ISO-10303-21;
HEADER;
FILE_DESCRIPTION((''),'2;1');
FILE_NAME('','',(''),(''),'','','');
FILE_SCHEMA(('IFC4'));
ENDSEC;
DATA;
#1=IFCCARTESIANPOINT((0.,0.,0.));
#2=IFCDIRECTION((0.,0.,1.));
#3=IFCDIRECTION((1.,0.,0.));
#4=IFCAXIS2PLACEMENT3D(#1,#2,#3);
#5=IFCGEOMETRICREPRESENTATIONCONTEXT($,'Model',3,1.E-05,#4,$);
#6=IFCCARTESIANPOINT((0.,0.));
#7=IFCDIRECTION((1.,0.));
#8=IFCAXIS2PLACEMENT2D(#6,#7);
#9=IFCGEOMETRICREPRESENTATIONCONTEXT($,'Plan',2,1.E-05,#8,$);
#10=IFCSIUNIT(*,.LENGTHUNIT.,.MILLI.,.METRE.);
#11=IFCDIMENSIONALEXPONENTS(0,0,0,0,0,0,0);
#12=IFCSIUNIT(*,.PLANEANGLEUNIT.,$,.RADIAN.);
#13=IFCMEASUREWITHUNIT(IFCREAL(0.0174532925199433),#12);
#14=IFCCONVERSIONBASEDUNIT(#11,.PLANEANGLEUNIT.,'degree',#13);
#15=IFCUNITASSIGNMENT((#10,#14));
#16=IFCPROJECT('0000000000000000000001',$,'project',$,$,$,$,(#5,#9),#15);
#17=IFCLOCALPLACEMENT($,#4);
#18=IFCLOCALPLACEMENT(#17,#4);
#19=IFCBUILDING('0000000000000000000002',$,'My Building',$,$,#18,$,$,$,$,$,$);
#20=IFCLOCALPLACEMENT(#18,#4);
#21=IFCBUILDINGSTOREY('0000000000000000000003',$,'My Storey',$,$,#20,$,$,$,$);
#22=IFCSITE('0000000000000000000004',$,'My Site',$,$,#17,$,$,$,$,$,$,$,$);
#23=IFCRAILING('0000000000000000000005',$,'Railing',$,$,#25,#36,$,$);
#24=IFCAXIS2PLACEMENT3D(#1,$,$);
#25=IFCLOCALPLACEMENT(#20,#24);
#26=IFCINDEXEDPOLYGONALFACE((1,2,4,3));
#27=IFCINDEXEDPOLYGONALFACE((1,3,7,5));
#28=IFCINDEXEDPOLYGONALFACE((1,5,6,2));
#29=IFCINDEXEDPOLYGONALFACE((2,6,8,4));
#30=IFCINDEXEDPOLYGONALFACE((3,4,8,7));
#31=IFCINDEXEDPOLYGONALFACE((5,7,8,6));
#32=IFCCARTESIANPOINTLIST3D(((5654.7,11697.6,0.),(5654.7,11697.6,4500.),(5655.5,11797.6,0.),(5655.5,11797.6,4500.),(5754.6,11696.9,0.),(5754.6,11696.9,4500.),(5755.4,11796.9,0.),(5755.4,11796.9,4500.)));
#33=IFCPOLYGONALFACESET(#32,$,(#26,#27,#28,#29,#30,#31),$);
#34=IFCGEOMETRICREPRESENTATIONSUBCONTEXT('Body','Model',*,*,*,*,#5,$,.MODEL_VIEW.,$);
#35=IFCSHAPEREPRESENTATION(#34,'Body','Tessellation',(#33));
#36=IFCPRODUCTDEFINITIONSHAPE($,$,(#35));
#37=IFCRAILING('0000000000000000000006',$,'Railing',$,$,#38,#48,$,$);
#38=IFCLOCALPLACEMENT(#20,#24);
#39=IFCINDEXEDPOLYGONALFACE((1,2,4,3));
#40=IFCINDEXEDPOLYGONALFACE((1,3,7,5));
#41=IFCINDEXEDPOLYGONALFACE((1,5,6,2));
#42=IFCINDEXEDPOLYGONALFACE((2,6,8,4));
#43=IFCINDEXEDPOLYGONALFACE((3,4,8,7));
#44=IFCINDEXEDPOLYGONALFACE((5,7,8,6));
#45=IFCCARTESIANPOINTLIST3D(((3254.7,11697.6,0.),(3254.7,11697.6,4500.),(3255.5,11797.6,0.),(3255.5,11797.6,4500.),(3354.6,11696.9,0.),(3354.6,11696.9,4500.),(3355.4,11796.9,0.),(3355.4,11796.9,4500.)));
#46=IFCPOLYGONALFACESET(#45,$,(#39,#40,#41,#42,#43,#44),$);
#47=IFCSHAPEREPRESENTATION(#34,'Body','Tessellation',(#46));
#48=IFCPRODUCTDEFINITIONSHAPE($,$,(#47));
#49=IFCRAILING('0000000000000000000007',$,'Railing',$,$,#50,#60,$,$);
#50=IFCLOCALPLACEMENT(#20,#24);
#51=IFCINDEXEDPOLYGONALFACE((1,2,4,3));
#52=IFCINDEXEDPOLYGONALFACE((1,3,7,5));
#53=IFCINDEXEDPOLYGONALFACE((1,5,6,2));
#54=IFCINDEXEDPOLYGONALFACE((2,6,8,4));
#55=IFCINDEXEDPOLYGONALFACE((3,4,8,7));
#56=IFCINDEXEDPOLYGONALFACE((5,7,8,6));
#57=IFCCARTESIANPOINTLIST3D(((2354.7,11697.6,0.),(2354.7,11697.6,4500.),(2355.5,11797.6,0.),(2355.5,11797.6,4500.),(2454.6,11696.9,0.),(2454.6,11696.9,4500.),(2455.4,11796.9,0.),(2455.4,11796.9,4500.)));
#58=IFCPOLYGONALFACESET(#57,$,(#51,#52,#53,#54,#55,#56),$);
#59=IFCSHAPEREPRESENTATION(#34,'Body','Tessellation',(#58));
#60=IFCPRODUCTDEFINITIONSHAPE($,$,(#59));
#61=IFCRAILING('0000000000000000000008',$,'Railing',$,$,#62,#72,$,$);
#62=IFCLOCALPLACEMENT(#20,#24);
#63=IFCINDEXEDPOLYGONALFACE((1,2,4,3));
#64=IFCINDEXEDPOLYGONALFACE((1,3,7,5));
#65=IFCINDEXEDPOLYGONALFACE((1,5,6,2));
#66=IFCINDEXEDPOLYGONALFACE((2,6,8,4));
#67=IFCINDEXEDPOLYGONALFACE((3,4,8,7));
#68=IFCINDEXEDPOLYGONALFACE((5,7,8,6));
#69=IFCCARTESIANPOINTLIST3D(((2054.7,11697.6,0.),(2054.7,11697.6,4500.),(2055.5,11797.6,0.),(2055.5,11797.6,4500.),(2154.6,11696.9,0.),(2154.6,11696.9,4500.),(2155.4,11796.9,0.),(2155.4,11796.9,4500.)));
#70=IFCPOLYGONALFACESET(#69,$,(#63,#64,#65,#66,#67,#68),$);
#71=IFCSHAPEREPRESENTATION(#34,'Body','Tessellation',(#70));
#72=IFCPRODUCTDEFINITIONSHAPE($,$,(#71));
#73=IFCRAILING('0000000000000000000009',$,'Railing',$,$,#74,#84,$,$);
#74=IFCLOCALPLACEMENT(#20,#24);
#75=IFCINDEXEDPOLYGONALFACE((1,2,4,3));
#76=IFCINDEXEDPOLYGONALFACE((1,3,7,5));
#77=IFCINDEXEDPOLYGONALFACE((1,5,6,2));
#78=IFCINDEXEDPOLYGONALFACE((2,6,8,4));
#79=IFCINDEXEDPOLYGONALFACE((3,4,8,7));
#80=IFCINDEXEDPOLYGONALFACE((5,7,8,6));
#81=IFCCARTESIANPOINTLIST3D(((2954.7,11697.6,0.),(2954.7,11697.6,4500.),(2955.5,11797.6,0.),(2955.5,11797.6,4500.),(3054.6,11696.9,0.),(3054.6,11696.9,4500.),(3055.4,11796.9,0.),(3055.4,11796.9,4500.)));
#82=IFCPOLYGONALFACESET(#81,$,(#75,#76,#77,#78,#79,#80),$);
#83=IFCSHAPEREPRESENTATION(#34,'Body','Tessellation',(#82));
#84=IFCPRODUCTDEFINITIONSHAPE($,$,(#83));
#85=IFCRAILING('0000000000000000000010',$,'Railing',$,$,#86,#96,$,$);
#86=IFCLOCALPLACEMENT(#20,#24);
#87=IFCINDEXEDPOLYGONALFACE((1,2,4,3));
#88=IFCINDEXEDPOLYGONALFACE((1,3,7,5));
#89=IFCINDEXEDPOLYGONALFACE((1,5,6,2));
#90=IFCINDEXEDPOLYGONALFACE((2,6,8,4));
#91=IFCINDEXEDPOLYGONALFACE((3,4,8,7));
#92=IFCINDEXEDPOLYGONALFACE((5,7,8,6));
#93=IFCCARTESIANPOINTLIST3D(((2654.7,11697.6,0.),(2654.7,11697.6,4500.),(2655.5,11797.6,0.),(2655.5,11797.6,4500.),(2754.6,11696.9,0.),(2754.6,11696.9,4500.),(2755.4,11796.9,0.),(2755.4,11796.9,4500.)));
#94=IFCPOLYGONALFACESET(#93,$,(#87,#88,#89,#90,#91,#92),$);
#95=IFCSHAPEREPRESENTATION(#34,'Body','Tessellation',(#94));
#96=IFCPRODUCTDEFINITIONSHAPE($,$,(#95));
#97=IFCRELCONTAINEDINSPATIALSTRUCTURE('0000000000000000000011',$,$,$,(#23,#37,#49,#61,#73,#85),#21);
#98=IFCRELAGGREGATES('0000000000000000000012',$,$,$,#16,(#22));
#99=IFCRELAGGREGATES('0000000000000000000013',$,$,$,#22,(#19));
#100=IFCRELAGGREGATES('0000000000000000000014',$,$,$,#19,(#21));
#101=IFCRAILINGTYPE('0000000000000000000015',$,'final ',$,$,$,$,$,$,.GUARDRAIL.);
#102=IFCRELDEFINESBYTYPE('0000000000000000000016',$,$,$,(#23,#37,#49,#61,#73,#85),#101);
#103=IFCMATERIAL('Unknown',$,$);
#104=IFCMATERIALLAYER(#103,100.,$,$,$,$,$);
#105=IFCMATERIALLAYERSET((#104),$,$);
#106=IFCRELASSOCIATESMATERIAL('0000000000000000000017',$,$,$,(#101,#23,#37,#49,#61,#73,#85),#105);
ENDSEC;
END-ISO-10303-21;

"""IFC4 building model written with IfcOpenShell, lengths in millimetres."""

from ifc_helpers import new_model, entity, si_unit, converted_unit, frame, origin_with_axes, origin_2d_with_axis, place, context, subcontext, project, spatial, line, indexed_curve, outline, extrude, material, layer, layer_set, layer_usage, type_object, element, save


model = new_model("IFC4")

# Units and contexts
model_context = context("Model", 3, precision=1e-05, world=origin_with_axes())
plan_context = context("Plan", 2, precision=1e-05, world=origin_2d_with_axis())
body_context = subcontext(model_context, "Body", "Model", "MODEL_VIEW")
ifc_project = project(units=[si_unit("LENGTHUNIT", "METRE", prefix="MILLI"), converted_unit("PLANEANGLEUNIT", "degree", entity("IfcReal", 0.0174532925199433), si_unit("PLANEANGLEUNIT", "RADIAN"), dimensions=[0, 0, 0, 0, 0, 0, 0])], contexts=[model_context, plan_context])

# Site, building, storey
site_placement = place(None, origin_with_axes())
site = spatial("IfcSite", under=ifc_project, at=site_placement, Name="My Site")
building_placement = place(site_placement, origin_with_axes())
building = spatial("IfcBuilding", under=site, at=building_placement, Name="My Building")
storey_placement = place(building_placement, origin_with_axes())
storey = spatial("IfcBuildingStorey", under=building, at=storey_placement, Name="My Storey")

# Shared definitions
ifc_material = material(Name="Unknown")

# Railings
ifc_layer_1 = layer(ifc_material, 100.0)
ifc_layer_set_1 = layer_set([ifc_layer_1])
railing_type = type_object("IfcRailingType", Name="final ", PredefinedType="GUARDRAIL", material=ifc_layer_set_1)
ifc_layer_usage_1 = layer_usage(ifc_layer_set_1, "AXIS2", "POSITIVE", 0.0)
railing_1_placement = place(storey_placement, frame((5755.4, 11796.9, 0.0), z_axis=(0.0, 0.0, 1.0), x_axis=(-0.99997, 0.007689, 0.0)))
element("IfcRailing", 1, at=railing_1_placement, inside=storey, type_object=railing_type, material=ifc_layer_usage_1, Name="Railing", context=body_context, shape_type="SweptSolid", body=[
    extrude(outline(indexed_curve([(0.0, 0.0), (0.0, 100.0), (99.8, 100.0), (99.8, 0.0)], segments=[line(1, 2, 3, 4, 1)])), origin_with_axes(), (0.0, 0.0, 1.0), 4500.0),
])
ifc_layer_usage_2 = layer_usage(ifc_layer_set_1, "AXIS2", "POSITIVE", 0.0)
railing_2_placement = place(storey_placement, frame((3355.4, 11796.9, 0.0), z_axis=(0.0, 0.0, 1.0), x_axis=(-0.99997, 0.007689, 0.0)))
element("IfcRailing", 2, at=railing_2_placement, inside=storey, type_object=railing_type, material=ifc_layer_usage_2, Name="Railing", context=body_context, shape_type="SweptSolid", body=[
    extrude(outline(indexed_curve([(0.0, 0.0), (0.0, 100.0), (99.8, 100.0), (99.8, 0.0)], segments=[line(1, 2, 3, 4, 1)])), origin_with_axes(), (0.0, 0.0, 1.0), 4500.0),
])
ifc_layer_usage_3 = layer_usage(ifc_layer_set_1, "AXIS2", "POSITIVE", 0.0)
railing_3_placement = place(storey_placement, frame((2455.4, 11796.9, 0.0), z_axis=(0.0, 0.0, 1.0), x_axis=(-0.99997, 0.007689, 0.0)))
element("IfcRailing", 3, at=railing_3_placement, inside=storey, type_object=railing_type, material=ifc_layer_usage_3, Name="Railing", context=body_context, shape_type="SweptSolid", body=[
    extrude(outline(indexed_curve([(0.0, 0.0), (0.0, 100.0), (99.8, 100.0), (99.8, 0.0)], segments=[line(1, 2, 3, 4, 1)])), origin_with_axes(), (0.0, 0.0, 1.0), 4500.0),
])
ifc_layer_usage_4 = layer_usage(ifc_layer_set_1, "AXIS2", "POSITIVE", 0.0)
railing_4_placement = place(storey_placement, frame((2155.4, 11796.9, 0.0), z_axis=(0.0, 0.0, 1.0), x_axis=(-0.99997, 0.007689, 0.0)))
element("IfcRailing", 4, at=railing_4_placement, inside=storey, type_object=railing_type, material=ifc_layer_usage_4, Name="Railing", context=body_context, shape_type="SweptSolid", body=[
    extrude(outline(indexed_curve([(0.0, 0.0), (0.0, 100.0), (99.8, 100.0), (99.8, 0.0)], segments=[line(1, 2, 3, 4, 1)])), origin_with_axes(), (0.0, 0.0, 1.0), 4500.0),
])
ifc_layer_usage_5 = layer_usage(ifc_layer_set_1, "AXIS2", "POSITIVE", 0.0)
railing_5_placement = place(storey_placement, frame((3055.4, 11796.9, 0.0), z_axis=(0.0, 0.0, 1.0), x_axis=(-0.99997, 0.007689, 0.0)))
element("IfcRailing", 5, at=railing_5_placement, inside=storey, type_object=railing_type, material=ifc_layer_usage_5, Name="Railing", context=body_context, shape_type="SweptSolid", body=[
    extrude(outline(indexed_curve([(0.0, 0.0), (0.0, 100.0), (99.8, 100.0), (99.8, 0.0)], segments=[line(1, 2, 3, 4, 1)])), origin_with_axes(), (0.0, 0.0, 1.0), 4500.0),
])
ifc_layer_usage_6 = layer_usage(ifc_layer_set_1, "AXIS2", "POSITIVE", 0.0)
railing_6_placement = place(storey_placement, frame((2755.4, 11796.9, 0.0), z_axis=(0.0, 0.0, 1.0), x_axis=(-0.99997, 0.007689, 0.0)))
element("IfcRailing", 6, at=railing_6_placement, inside=storey, type_object=railing_type, material=ifc_layer_usage_6, Name="Railing", context=body_context, shape_type="SweptSolid", body=[
    extrude(outline(indexed_curve([(0.0, 0.0), (0.0, 100.0), (99.8, 100.0), (99.8, 0.0)], segments=[line(1, 2, 3, 4, 1)])), origin_with_axes(), (0.0, 0.0, 1.0), 4500.0),
])

save(model, "model.ifc")
